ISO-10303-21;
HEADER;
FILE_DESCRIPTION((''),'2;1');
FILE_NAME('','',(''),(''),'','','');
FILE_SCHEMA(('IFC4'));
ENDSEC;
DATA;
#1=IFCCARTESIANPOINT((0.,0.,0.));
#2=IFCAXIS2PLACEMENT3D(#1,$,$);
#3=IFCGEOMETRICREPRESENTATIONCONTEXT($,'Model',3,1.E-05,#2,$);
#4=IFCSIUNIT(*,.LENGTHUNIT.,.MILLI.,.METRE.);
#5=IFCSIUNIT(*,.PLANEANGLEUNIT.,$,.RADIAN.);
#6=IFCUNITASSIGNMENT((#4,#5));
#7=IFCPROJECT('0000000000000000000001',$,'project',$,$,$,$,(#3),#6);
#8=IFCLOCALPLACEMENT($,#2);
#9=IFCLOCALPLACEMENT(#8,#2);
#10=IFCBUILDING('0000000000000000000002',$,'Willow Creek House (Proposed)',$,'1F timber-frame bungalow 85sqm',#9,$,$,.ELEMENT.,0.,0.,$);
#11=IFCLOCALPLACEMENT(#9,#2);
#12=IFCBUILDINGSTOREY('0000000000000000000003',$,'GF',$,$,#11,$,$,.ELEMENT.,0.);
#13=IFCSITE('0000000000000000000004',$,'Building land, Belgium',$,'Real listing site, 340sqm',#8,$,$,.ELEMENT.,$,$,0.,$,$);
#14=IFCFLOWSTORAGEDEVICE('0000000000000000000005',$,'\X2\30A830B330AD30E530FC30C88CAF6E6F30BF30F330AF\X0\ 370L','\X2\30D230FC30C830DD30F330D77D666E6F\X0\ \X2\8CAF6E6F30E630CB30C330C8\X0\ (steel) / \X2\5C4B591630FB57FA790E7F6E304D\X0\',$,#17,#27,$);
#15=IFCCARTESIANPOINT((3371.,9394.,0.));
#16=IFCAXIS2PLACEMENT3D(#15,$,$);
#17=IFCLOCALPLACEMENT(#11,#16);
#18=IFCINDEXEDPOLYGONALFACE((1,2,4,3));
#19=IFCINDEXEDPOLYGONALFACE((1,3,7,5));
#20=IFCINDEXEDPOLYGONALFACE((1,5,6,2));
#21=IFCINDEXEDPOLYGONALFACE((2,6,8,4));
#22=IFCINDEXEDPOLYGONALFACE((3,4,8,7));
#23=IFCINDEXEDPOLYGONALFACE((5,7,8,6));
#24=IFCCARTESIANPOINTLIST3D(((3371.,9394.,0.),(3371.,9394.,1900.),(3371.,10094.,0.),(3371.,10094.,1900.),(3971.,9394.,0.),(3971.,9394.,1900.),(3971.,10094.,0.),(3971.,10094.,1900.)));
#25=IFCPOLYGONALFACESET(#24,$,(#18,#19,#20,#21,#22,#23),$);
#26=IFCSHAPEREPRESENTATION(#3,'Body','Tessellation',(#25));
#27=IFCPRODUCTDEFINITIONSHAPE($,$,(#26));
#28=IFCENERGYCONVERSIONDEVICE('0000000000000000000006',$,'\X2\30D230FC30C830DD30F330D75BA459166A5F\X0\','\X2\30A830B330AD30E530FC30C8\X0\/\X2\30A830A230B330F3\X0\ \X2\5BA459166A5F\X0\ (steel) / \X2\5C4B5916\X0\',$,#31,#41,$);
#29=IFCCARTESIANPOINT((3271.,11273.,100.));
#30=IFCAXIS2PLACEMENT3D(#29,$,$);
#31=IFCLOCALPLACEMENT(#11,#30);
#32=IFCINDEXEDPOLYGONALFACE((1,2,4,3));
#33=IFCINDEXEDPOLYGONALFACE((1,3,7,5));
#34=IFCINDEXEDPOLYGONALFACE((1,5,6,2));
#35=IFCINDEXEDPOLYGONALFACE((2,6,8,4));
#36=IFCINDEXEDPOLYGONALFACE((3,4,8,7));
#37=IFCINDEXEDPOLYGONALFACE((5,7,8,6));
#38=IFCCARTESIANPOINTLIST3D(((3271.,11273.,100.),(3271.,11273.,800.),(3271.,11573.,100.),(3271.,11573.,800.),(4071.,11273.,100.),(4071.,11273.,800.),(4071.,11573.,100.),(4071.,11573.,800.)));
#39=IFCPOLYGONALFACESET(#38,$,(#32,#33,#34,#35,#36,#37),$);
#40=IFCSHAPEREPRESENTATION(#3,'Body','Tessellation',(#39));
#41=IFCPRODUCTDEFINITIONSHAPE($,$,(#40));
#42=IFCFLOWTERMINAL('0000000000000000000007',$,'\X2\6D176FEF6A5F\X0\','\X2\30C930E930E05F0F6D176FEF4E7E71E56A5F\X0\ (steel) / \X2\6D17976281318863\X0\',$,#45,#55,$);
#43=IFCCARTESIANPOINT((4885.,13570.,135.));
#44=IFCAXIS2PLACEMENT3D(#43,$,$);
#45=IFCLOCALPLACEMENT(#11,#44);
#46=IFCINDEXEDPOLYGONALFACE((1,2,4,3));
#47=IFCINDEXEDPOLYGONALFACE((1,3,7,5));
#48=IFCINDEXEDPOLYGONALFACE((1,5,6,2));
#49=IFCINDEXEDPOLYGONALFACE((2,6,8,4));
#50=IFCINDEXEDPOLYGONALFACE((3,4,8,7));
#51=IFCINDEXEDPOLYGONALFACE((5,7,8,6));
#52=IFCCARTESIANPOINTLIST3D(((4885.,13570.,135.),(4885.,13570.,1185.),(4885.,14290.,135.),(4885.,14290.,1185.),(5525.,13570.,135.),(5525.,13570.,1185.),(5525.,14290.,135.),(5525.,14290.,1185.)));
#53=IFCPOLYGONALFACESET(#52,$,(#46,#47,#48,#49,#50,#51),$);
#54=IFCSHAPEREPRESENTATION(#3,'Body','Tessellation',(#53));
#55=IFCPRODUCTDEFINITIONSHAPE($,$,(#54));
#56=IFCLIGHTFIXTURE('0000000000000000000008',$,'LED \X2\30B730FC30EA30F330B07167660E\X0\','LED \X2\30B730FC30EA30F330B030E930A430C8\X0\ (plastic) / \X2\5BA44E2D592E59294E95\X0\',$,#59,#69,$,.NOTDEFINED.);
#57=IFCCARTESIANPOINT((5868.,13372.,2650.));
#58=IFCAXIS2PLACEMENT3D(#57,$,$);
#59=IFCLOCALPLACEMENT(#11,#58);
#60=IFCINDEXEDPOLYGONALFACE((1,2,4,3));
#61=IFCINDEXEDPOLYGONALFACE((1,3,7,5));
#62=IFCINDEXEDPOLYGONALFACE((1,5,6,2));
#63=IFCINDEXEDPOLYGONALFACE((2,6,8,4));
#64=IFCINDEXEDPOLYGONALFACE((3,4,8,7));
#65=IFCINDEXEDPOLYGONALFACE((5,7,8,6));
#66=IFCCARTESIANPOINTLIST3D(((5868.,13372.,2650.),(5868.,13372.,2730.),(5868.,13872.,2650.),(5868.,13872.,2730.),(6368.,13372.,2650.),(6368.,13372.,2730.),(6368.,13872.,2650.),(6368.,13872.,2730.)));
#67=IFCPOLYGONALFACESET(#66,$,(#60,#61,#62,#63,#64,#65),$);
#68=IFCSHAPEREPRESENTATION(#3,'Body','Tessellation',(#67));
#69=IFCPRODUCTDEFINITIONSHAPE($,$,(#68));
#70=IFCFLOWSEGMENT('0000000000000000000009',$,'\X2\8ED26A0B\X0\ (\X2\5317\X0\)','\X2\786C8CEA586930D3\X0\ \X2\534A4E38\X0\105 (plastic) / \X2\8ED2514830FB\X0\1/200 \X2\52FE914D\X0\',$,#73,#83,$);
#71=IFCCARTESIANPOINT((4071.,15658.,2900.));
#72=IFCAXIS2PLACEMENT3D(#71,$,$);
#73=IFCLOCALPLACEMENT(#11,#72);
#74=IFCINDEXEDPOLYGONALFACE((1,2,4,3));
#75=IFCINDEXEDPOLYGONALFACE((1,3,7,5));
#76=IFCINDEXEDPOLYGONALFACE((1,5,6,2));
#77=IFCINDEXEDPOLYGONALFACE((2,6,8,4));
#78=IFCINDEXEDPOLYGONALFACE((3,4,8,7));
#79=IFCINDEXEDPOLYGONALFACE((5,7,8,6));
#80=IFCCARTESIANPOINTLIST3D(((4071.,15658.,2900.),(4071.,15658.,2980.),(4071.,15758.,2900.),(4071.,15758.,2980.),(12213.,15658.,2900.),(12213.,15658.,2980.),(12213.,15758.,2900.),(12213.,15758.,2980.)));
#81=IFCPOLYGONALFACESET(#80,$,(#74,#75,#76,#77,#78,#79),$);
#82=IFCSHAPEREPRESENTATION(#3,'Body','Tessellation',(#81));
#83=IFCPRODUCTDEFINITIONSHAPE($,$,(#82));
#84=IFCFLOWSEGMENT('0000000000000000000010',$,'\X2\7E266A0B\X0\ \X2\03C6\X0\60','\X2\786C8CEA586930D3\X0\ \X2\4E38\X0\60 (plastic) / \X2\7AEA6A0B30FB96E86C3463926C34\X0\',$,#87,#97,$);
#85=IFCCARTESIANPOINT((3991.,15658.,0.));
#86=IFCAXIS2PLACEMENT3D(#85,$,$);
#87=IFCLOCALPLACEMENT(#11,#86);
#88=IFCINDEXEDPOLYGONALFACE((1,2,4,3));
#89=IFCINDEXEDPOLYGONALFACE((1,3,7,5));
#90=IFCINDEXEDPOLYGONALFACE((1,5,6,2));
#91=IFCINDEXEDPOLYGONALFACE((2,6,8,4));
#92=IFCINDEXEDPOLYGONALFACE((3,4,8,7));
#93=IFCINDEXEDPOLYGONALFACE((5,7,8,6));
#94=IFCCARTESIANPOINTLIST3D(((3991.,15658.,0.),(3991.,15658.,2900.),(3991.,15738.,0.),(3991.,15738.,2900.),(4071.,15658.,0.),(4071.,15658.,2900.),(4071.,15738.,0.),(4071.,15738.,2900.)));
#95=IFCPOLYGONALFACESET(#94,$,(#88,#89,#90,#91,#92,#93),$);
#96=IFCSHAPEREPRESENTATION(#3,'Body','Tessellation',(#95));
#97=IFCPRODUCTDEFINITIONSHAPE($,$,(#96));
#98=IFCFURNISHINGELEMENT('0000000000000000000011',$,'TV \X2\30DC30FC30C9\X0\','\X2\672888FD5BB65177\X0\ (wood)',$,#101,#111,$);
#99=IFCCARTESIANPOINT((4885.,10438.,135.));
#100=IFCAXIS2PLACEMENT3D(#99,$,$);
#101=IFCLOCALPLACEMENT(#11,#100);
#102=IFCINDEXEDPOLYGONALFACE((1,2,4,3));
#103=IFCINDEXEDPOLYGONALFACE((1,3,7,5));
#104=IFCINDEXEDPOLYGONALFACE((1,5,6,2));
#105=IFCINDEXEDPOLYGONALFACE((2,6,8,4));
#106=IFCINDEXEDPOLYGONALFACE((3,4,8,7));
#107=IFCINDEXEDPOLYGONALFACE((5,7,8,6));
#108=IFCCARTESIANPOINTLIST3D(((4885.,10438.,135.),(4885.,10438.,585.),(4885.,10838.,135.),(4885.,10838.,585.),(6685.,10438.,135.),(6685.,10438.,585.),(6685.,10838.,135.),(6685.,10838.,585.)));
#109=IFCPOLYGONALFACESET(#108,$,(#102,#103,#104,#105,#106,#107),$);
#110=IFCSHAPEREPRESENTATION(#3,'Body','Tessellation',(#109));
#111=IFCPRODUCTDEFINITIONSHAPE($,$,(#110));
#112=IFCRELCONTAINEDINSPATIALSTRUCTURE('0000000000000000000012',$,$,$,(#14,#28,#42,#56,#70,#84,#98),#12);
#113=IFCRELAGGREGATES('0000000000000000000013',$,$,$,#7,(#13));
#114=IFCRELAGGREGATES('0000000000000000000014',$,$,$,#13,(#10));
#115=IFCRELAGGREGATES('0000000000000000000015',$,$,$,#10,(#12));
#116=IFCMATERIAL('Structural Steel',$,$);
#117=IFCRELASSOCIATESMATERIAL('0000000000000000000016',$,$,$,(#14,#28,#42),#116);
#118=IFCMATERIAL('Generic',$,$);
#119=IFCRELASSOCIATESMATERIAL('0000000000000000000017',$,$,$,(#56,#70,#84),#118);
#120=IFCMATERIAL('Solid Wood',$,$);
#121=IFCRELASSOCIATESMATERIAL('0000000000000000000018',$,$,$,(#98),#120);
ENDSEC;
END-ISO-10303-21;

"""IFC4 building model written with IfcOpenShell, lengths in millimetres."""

from ifc_helpers import new_model, si_unit, frame, frame_2d, origin, place, context, project, spatial, rectangle, extrude, material, element, save


model = new_model("IFC4")

# Units and contexts
model_context = context("Model", 3, precision=1e-05, world=origin())
ifc_project = project(units=[si_unit("LENGTHUNIT", "METRE", prefix="MILLI"), si_unit("PLANEANGLEUNIT", "RADIAN")], contexts=[model_context])

# Site, building, storey
site_placement = place(None, origin())
site = spatial("IfcSite", under=ifc_project, at=site_placement, Name="Building land, Belgium", ObjectType="Real listing site, 340sqm", CompositionType="ELEMENT", RefElevation=0.0)
building_placement = place(site_placement, origin())
building = spatial("IfcBuilding", under=site, at=building_placement, Name="Willow Creek House (Proposed)", ObjectType="1F timber-frame bungalow 85sqm", CompositionType="ELEMENT", ElevationOfRefHeight=0.0, ElevationOfTerrain=0.0)
storey_placement = place(building_placement, origin())
storey = spatial("IfcBuildingStorey", under=building, at=storey_placement, Name="GF", CompositionType="ELEMENT", Elevation=0.0)

# Shared definitions
ifc_material_1 = material(Name="Solid Wood")

# Shared definitions
ifc_material_2 = material(Name="Structural Steel")

# Shared definitions
ifc_material_3 = material(Name="Generic")

# Flow storage device
flow_storage_device_placement = place(storey_placement, frame((3371.0, 9394.0, 0.0)))
element("IfcFlowStorageDevice", 1, at=flow_storage_device_placement, inside=storey, material=ifc_material_2, Name="エコキュート貯湯タンク 370L", Description="ヒートポンプ給湯 貯湯ユニット (steel) / 屋外・基礎置き", context=model_context, shape_type="SweptSolid", body=[
    extrude(rectangle(XDim=600.0, YDim=700.0, at=frame_2d((300.0, 350.0))), frame((3371.0, 9394.0, 0.0)), (0.0, 0.0, 1.0), 1900.0),
])

# Energy conversion device
energy_conversion_device_placement = place(storey_placement, frame((3271.0, 11273.0, 100.0)))
element("IfcEnergyConversionDevice", 2, at=energy_conversion_device_placement, inside=storey, material=ifc_material_2, Name="ヒートポンプ室外機", Description="エコキュート/エアコン 室外機 (steel) / 屋外", context=model_context, shape_type="SweptSolid", body=[
    extrude(rectangle(XDim=800.0, YDim=300.0, at=frame_2d((400.0, 150.0))), frame((3271.0, 11273.0, 100.0)), (0.0, 0.0, 1.0), 700.0),
])

# Flow terminal
flow_terminal_placement = place(storey_placement, frame((4885.0, 13570.0, 135.0)))
element("IfcFlowTerminal", 3, at=flow_terminal_placement, inside=storey, material=ifc_material_2, Name="洗濯機", Description="ドラム式洗濯乾燥機 (steel) / 洗面脱衣", context=model_context, shape_type="SweptSolid", body=[
    extrude(rectangle(XDim=640.0, YDim=720.0, at=frame_2d((320.0, 360.0))), frame((4885.0, 13570.0, 135.0)), (0.0, 0.0, 1.0), 1050.0),
])

# Light fixture
light_fixture_placement = place(storey_placement, frame((5868.0, 13372.0, 2650.0)))
element("IfcLightFixture", 4, at=light_fixture_placement, inside=storey, material=ifc_material_3, Name="LED シーリング照明", Description="LED シーリングライト (plastic) / 室中央天井", PredefinedType="NOTDEFINED", context=model_context, shape_type="SweptSolid", body=[
    extrude(rectangle(XDim=500.0, YDim=500.0, at=frame_2d((250.0, 250.0))), frame((5868.0, 13372.0, 2650.0)), (0.0, 0.0, 1.0), 80.0),
])

# Flow segments
flow_segment_1_placement = place(storey_placement, frame((4071.0, 15658.0, 2900.0)))
element("IfcFlowSegment", 5, at=flow_segment_1_placement, inside=storey, material=ifc_material_3, Name="軒樋 (北)", Description="硬質塩ビ 半丸105 (plastic) / 軒先・1/200 勾配", context=model_context, shape_type="SweptSolid", body=[
    extrude(rectangle(XDim=8142.0, YDim=100.0, at=frame_2d((4071.0, 50.0))), frame((4071.0, 15658.0, 2900.0)), (0.0, 0.0, 1.0), 80.0),
])
flow_segment_2_placement = place(storey_placement, frame((3991.0, 15658.0, 0.0)))
element("IfcFlowSegment", 6, at=flow_segment_2_placement, inside=storey, material=ifc_material_3, Name="縦樋 φ60", Description="硬質塩ビ 丸60 (plastic) / 竪樋・雨水排水", context=model_context, shape_type="SweptSolid", body=[
    extrude(rectangle(XDim=80.0, YDim=80.0, at=frame_2d((40.0, 40.0))), frame((3991.0, 15658.0, 0.0)), (0.0, 0.0, 1.0), 2900.0),
])

# Furnishing element
furnishing_placement = place(storey_placement, frame((4885.0, 10438.0, 135.0)))
element("IfcFurnishingElement", 7, at=furnishing_placement, inside=storey, material=ifc_material_1, Name="TV ボード", Description="木製家具 (wood)", context=model_context, shape_type="SweptSolid", body=[
    extrude(rectangle(XDim=1800.0, YDim=400.0, at=frame_2d((900.0, 200.0))), frame((4885.0, 10438.0, 135.0)), (0.0, 0.0, 1.0), 450.0),
])

save(model, "model.ifc")
